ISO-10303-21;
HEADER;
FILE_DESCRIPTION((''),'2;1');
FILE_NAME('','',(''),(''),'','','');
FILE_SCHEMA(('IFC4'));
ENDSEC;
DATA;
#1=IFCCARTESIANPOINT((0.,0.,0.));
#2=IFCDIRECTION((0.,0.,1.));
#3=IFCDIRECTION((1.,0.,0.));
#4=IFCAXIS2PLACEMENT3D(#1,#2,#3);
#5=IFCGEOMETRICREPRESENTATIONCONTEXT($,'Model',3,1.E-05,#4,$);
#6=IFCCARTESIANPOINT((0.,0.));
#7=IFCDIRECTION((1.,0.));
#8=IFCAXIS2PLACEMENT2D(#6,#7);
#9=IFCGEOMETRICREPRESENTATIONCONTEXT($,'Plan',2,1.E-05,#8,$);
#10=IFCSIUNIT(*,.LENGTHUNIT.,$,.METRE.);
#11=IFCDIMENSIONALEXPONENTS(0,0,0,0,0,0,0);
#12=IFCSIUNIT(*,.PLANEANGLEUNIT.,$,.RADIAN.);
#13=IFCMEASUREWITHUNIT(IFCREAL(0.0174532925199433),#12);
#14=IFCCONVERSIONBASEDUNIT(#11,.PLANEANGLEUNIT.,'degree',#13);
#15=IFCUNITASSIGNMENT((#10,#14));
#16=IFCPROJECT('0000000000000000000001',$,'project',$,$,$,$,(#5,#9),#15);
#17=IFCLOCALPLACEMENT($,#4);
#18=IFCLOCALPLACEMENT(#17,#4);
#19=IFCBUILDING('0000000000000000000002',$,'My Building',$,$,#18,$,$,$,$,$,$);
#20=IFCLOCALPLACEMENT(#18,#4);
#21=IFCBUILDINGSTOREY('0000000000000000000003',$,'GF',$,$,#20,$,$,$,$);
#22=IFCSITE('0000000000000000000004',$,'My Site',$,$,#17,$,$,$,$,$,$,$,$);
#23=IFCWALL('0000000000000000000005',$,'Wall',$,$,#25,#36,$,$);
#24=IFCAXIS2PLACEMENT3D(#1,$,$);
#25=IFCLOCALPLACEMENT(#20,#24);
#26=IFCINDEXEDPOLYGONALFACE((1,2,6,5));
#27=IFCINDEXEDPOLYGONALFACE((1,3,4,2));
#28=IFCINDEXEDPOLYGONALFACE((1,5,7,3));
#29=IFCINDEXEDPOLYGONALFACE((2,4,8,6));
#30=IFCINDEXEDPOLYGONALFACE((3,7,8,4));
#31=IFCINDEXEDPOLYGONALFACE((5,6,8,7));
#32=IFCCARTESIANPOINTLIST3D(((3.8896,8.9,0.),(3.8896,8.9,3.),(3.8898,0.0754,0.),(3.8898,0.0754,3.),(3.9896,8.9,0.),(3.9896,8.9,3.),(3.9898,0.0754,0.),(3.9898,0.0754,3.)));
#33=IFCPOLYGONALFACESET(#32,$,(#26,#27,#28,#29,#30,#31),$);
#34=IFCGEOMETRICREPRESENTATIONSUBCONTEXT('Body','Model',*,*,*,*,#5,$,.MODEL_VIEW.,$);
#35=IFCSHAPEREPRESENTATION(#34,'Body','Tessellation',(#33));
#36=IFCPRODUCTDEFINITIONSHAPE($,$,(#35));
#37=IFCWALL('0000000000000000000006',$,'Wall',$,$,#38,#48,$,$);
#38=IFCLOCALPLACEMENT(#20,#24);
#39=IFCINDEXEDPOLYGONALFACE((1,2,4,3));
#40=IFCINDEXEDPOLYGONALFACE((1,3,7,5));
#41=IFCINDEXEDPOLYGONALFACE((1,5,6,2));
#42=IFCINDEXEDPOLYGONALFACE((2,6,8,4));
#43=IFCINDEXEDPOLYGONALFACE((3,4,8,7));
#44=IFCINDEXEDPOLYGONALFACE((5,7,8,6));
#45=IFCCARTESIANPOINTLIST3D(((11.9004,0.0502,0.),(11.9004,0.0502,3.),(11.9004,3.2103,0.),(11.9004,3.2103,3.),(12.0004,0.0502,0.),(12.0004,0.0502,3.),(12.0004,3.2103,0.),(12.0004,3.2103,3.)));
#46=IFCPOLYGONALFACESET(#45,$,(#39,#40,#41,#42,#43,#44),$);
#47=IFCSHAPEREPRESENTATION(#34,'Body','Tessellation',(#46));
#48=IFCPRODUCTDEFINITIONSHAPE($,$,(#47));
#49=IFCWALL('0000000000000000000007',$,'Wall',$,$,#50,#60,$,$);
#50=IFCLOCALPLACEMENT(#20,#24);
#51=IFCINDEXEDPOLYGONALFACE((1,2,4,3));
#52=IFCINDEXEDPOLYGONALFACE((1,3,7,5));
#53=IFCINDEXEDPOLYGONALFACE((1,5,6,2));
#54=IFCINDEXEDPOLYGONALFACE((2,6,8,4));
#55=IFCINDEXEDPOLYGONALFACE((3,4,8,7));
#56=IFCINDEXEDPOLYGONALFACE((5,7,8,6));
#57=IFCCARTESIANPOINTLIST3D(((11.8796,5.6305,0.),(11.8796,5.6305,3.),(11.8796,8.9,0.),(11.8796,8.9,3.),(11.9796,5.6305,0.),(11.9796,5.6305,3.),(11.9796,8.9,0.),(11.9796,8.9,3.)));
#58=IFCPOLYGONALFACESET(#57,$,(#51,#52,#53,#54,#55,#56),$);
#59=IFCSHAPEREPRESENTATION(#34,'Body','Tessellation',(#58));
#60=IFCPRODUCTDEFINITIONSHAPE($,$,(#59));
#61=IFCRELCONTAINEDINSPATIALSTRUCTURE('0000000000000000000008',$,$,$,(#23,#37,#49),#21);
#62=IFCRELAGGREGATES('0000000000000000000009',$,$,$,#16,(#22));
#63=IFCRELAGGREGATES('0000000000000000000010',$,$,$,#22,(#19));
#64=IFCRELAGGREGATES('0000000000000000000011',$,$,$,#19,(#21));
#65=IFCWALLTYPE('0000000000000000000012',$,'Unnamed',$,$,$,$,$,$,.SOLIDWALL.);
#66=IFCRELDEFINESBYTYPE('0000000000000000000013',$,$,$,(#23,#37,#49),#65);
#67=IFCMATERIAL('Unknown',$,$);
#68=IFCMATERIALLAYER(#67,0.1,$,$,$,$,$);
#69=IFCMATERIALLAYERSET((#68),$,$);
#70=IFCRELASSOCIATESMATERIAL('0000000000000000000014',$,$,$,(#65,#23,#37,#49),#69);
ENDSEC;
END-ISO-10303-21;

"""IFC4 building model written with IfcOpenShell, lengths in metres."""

from ifc_helpers import new_model, entity, si_unit, converted_unit, frame, origin_with_axes, origin_2d_with_axis, place, context, subcontext, project, spatial, line, indexed_curve, outline, extrude, material, layer, layer_set, layer_usage, type_object, element, save


model = new_model("IFC4")

# Units and contexts
model_context = context("Model", 3, precision=1e-05, world=origin_with_axes())
plan_context = context("Plan", 2, precision=1e-05, world=origin_2d_with_axis())
body_context_1 = subcontext(model_context, "Body", "Model", "MODEL_VIEW")
ifc_project = project(units=[si_unit("LENGTHUNIT", "METRE"), converted_unit("PLANEANGLEUNIT", "degree", entity("IfcReal", 0.0174532925199433), si_unit("PLANEANGLEUNIT", "RADIAN"), dimensions=[0, 0, 0, 0, 0, 0, 0])], contexts=[model_context, plan_context])

# Site, building, storey
site_placement = place(None, origin_with_axes())
site = spatial("IfcSite", under=ifc_project, at=site_placement, Name="My Site")
building_placement = place(site_placement, origin_with_axes())
building = spatial("IfcBuilding", under=site, at=building_placement, Name="My Building")
storey_placement = place(building_placement, origin_with_axes())
storey = spatial("IfcBuildingStorey", under=building, at=storey_placement, Name="GF")

# Shared definitions
ifc_material = material(Name="Unknown")
ifc_layer = layer(ifc_material, 0.1)
ifc_layer_set = layer_set([ifc_layer])
wall_type = type_object("IfcWallType", Name="Unnamed", PredefinedType="SOLIDWALL", material=ifc_layer_set)

# Walls
ifc_layer_usage_1 = layer_usage(ifc_layer_set, "AXIS2", "POSITIVE", 0.0)
wall_1_placement = place(storey_placement, frame((3.9898, 0.0754, 0.0), z_axis=(0.0, 0.0, 1.0), x_axis=(-0.000021, 1.0, 0.0)))
element("IfcWall", 1, at=wall_1_placement, inside=storey, type_object=wall_type, material=ifc_layer_usage_1, Name="Wall", context=body_context_1, shape_type="SweptSolid", body=[
    extrude(outline(indexed_curve([(0.0, 0.0), (0.0, 0.1), (8.8246, 0.1), (8.8246, 0.0)], segments=[line(1, 2, 3, 4, 1)])), origin_with_axes(), (0.0, 0.0, 1.0), 3.0),
])
ifc_layer_usage_2 = layer_usage(ifc_layer_set, "AXIS2", "POSITIVE", 0.0)
wall_2_placement = place(storey_placement, frame((12.0004, 0.0502, 0.0), z_axis=(0.0, 0.0, 1.0), x_axis=(0.000013, 1.0, 0.0)))
element("IfcWall", 2, at=wall_2_placement, inside=storey, type_object=wall_type, material=ifc_layer_usage_2, Name="Wall", context=body_context_1, shape_type="SweptSolid", body=[
    extrude(outline(indexed_curve([(0.0, 0.0), (0.0, 0.1), (3.1602, 0.1), (3.1602, 0.0)], segments=[line(1, 2, 3, 4, 1)])), origin_with_axes(), (0.0, 0.0, 1.0), 3.0),
])
ifc_layer_usage_3 = layer_usage(ifc_layer_set, "AXIS2", "POSITIVE", 0.0)
wall_3_placement = place(storey_placement, frame((11.9796, 5.6305, 0.0), z_axis=(0.0, 0.0, 1.0), x_axis=(0.0, 1.0, 0.0)))
element("IfcWall", 3, at=wall_3_placement, inside=storey, type_object=wall_type, material=ifc_layer_usage_3, Name="Wall", context=body_context_1, shape_type="SweptSolid", body=[
    extrude(outline(indexed_curve([(0.0, 0.0), (0.0, 0.1), (3.2695, 0.1), (3.2695, 0.0)], segments=[line(1, 2, 3, 4, 1)])), origin_with_axes(), (0.0, 0.0, 1.0), 3.0),
])

save(model, "model.ifc")
